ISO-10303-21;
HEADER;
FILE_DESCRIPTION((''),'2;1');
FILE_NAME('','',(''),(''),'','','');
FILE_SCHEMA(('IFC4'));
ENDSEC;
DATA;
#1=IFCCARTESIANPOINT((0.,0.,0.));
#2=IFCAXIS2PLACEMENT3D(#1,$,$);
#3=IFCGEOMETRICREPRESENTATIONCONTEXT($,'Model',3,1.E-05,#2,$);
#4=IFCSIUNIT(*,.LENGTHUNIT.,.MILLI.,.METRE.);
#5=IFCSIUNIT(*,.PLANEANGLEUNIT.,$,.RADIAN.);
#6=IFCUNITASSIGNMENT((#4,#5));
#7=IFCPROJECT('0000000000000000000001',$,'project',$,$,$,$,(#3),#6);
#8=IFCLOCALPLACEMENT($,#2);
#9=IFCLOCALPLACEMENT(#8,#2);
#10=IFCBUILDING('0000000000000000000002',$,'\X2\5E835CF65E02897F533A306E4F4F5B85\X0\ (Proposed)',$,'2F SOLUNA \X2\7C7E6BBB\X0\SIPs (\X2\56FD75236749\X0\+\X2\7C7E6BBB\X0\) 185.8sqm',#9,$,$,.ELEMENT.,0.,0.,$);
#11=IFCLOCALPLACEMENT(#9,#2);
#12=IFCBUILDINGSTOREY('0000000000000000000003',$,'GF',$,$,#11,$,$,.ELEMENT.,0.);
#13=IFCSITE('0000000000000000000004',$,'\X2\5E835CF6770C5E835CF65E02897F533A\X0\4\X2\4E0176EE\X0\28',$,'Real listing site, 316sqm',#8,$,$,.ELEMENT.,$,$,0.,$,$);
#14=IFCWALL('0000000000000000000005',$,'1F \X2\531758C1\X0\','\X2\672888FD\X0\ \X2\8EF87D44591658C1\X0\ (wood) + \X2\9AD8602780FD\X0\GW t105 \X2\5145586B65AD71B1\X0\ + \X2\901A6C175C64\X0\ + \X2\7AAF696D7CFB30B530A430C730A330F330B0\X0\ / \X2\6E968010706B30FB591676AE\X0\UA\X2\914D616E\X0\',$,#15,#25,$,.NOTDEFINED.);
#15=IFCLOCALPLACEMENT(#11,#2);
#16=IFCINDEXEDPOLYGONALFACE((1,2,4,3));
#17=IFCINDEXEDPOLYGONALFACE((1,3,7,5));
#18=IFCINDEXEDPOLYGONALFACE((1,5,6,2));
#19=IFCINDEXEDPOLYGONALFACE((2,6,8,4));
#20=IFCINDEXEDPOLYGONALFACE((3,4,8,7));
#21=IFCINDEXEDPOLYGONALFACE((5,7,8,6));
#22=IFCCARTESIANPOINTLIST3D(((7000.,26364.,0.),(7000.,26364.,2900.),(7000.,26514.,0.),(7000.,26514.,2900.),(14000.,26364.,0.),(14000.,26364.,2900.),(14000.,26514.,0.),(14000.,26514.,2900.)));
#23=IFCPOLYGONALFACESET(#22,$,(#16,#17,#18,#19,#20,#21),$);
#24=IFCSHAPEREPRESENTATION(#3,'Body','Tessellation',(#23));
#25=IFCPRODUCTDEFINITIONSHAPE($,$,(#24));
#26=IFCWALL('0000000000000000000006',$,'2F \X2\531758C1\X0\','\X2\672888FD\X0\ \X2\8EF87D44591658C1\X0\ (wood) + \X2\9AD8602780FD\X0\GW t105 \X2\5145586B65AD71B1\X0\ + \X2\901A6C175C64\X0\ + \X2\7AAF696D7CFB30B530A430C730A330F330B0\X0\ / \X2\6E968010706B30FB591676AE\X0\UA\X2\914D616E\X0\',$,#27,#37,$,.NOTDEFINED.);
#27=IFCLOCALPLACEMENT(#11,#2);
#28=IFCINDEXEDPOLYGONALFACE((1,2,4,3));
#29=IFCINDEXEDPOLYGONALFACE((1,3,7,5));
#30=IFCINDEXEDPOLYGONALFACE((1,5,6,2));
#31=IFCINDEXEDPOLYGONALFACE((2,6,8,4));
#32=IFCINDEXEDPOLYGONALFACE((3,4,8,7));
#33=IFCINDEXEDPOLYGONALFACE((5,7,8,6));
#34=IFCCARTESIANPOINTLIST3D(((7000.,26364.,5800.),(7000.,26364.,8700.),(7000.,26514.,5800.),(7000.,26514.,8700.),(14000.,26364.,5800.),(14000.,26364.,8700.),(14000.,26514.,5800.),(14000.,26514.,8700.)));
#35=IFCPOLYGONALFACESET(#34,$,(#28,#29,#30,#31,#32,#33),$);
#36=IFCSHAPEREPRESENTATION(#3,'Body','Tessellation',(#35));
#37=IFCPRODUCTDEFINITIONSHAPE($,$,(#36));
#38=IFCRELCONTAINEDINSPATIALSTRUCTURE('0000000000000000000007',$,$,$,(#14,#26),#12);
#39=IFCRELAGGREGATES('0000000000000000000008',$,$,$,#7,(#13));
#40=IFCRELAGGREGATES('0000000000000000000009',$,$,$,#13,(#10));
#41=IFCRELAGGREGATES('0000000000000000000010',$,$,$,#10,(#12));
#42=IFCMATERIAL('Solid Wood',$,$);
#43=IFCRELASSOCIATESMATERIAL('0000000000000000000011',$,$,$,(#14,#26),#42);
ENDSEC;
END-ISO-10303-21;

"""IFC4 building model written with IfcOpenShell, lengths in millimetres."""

from ifc_helpers import new_model, si_unit, frame, frame_2d, origin, place, context, project, spatial, rectangle, extrude, material, element, save


model = new_model("IFC4")

# Units and contexts
model_context = context("Model", 3, precision=1e-05, world=origin())
ifc_project = project(units=[si_unit("LENGTHUNIT", "METRE", prefix="MILLI"), si_unit("PLANEANGLEUNIT", "RADIAN")], contexts=[model_context])

# Site, building, storey
site_placement = place(None, origin())
site = spatial("IfcSite", under=ifc_project, at=site_placement, Name="広島県広島市西区4丁目28", ObjectType="Real listing site, 316sqm", CompositionType="ELEMENT", RefElevation=0.0)
building_placement = place(site_placement, origin())
building = spatial("IfcBuilding", under=site, at=building_placement, Name="広島市西区の住宅 (Proposed)", ObjectType="2F SOLUNA 籾殻SIPs (国産杉+籾殻) 185.8sqm", CompositionType="ELEMENT", ElevationOfRefHeight=0.0, ElevationOfTerrain=0.0)
storey_placement = place(building_placement, origin())
storey = spatial("IfcBuildingStorey", under=building, at=storey_placement, Name="GF", CompositionType="ELEMENT", Elevation=0.0)

# Shared definitions
ifc_material_1 = material(Name="Solid Wood")

# Wall
wall_1_placement = place(storey_placement, frame((3500.0, 13182.0, 0.0)))
element("IfcWall", 1, at=wall_1_placement, inside=storey, material=ifc_material_1, Name="1F 北壁", Description="木製 軸組外壁 (wood) + 高性能GW t105 充填断熱 + 通気層 + 窯業系サイディング / 準耐火・外皮UA配慮", PredefinedType="NOTDEFINED", context=model_context, shape_type="SweptSolid", body=[
    extrude(rectangle(XDim=7000.0, YDim=150.0, at=frame_2d((3500.0, 75.0))), frame((3500.0, 13182.0, 0.0)), (0.0, 0.0, 1.0), 2900.0),
])

# Wall
wall_2_placement = place(storey_placement, frame((3500.0, 13182.0, 2900.0)))
element("IfcWall", 2, at=wall_2_placement, inside=storey, material=ifc_material_1, Name="2F 北壁", Description="木製 軸組外壁 (wood) + 高性能GW t105 充填断熱 + 通気層 + 窯業系サイディング / 準耐火・外皮UA配慮", PredefinedType="NOTDEFINED", context=model_context, shape_type="SweptSolid", body=[
    extrude(rectangle(XDim=7000.0, YDim=150.0, at=frame_2d((3500.0, 75.0))), frame((3500.0, 13182.0, 2900.0)), (0.0, 0.0, 1.0), 2900.0),
])

save(model, "model.ifc")
